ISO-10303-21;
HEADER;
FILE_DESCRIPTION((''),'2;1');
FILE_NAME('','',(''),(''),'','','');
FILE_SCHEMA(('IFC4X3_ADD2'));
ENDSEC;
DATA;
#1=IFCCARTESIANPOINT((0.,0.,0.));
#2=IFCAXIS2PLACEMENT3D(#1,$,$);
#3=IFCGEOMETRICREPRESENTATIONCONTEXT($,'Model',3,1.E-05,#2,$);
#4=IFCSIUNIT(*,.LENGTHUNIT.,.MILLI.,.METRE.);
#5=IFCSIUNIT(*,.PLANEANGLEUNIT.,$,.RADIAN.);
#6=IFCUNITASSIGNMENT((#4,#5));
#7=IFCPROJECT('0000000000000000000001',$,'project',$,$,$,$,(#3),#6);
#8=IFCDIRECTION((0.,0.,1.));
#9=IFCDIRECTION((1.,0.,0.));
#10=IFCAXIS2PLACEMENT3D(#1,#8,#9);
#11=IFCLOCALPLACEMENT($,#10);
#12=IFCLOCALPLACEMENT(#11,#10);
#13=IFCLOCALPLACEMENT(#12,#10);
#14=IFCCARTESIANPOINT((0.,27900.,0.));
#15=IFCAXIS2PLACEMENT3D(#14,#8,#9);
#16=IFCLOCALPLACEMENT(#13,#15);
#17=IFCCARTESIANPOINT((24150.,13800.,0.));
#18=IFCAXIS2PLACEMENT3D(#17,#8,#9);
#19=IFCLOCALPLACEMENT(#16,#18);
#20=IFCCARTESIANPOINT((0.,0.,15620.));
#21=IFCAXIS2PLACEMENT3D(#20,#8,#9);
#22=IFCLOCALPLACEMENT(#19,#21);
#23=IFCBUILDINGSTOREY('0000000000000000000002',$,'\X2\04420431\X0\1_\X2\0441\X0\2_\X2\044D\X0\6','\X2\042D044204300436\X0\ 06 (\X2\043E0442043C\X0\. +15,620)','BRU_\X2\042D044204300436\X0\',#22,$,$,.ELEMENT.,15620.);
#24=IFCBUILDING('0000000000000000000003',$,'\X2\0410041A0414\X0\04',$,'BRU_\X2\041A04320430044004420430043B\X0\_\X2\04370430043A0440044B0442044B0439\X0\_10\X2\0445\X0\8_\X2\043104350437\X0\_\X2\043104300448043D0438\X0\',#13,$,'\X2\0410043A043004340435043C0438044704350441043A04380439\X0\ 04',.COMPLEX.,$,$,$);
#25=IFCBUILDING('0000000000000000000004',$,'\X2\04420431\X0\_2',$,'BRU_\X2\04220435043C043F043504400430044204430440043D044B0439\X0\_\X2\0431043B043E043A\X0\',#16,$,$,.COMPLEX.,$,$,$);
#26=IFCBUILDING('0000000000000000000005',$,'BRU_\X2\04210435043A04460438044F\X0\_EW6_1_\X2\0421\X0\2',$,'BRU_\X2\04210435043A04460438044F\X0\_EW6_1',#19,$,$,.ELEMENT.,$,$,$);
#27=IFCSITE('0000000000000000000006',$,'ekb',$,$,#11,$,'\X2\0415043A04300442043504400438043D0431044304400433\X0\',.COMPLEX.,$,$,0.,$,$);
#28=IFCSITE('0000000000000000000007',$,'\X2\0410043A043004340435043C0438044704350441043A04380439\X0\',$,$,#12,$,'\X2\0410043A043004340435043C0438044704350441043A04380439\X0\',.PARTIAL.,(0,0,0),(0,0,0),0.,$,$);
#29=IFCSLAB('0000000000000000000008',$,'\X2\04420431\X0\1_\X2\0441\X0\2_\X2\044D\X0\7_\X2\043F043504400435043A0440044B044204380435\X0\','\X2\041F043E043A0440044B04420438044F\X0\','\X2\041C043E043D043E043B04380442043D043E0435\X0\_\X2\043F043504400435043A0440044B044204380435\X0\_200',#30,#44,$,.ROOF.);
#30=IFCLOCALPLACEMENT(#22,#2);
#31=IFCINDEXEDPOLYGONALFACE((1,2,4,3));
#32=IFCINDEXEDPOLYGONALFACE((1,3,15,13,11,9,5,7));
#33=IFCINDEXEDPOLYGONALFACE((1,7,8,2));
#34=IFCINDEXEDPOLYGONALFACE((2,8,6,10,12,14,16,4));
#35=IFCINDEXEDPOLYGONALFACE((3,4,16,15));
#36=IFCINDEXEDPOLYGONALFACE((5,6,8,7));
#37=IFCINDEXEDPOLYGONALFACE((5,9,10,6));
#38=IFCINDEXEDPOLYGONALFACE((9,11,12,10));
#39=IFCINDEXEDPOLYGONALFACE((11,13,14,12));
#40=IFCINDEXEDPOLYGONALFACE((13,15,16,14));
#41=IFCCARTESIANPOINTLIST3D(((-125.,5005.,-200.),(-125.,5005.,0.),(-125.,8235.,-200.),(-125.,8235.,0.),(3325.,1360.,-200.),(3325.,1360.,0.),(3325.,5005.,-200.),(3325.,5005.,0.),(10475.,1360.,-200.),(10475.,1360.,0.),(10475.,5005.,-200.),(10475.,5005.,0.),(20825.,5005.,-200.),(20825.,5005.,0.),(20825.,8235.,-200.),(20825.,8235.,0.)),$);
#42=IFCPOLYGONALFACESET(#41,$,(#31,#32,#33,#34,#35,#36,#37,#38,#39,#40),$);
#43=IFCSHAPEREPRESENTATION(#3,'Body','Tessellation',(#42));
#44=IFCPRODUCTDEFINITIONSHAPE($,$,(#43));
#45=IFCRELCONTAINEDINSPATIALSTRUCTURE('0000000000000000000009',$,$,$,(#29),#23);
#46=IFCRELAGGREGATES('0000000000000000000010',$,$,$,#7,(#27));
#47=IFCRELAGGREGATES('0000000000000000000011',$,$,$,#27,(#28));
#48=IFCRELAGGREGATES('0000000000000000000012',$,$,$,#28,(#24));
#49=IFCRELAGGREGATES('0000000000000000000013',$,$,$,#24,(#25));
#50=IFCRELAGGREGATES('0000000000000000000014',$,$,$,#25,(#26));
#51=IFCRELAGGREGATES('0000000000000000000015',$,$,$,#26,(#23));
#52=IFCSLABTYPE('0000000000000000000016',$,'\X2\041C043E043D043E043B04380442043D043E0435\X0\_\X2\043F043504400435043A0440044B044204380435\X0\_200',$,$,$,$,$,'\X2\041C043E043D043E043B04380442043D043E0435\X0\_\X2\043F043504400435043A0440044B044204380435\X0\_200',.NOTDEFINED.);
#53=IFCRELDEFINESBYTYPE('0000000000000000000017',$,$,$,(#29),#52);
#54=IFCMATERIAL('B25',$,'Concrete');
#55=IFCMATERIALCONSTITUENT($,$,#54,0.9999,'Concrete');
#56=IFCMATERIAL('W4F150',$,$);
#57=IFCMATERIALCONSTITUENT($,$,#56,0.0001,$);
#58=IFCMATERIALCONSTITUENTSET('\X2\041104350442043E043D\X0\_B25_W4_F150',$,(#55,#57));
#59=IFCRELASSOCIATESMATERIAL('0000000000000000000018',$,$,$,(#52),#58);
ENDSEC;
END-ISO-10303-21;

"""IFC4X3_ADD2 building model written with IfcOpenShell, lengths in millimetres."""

from ifc_helpers import new_model, si_unit, frame, origin, origin_with_axes, place, context, project, spatial, polyline, outline, extrude, material, constituent, constituent_set, type_object, element, save


model = new_model("IFC4X3_ADD2")

# Units and contexts
model_context = context("Model", 3, precision=1e-05, world=origin())
ifc_project = project(units=[si_unit("LENGTHUNIT", "METRE", prefix="MILLI"), si_unit("PLANEANGLEUNIT", "RADIAN")], contexts=[model_context])

# Sites, buildings, storey
site_1_placement = place(None, origin_with_axes())
site_1 = spatial("IfcSite", under=ifc_project, at=site_1_placement, Name="ekb", LongName="Екатеринбург", CompositionType="COMPLEX", RefElevation=0.0)
site_2_placement = place(site_1_placement, origin_with_axes())
site_2 = spatial("IfcSite", under=site_1, at=site_2_placement, Name="Академический", LongName="Академический", CompositionType="PARTIAL", RefLatitude=(0, 0, 0), RefLongitude=(0, 0, 0), RefElevation=0.0)
building_1_placement = place(site_2_placement, origin_with_axes())
building_1 = spatial("IfcBuilding", under=site_2, at=building_1_placement, Name="АКД04", ObjectType="BRU_Квартал_закрытый_10х8_без_башни", LongName="Академический 04", CompositionType="COMPLEX")
building_2_placement = place(building_1_placement, frame((0.0, 27900.0, 0.0), z_axis=(0.0, 0.0, 1.0), x_axis=(1.0, 0.0, 0.0)))
building_2 = spatial("IfcBuilding", under=building_1, at=building_2_placement, Name="тб_2", ObjectType="BRU_Температурный_блок", CompositionType="COMPLEX")
building_3_placement = place(building_2_placement, frame((24150.0, 13800.0, 0.0), z_axis=(0.0, 0.0, 1.0), x_axis=(1.0, 0.0, 0.0)))
building_3 = spatial("IfcBuilding", under=building_2, at=building_3_placement, Name="BRU_Секция_EW6_1_С2", ObjectType="BRU_Секция_EW6_1", CompositionType="ELEMENT")
storey_placement = place(building_3_placement, frame((0.0, 0.0, 15620.0), z_axis=(0.0, 0.0, 1.0), x_axis=(1.0, 0.0, 0.0)))
storey = spatial("IfcBuildingStorey", under=building_3, at=storey_placement, Name="тб1_с2_э6", Description="Этаж 06 (отм. +15,620)", ObjectType="BRU_Этаж", CompositionType="ELEMENT", Elevation=15620.0)

# Slab
ifc_material_1 = material(Name="B25", Category="Concrete")
ifc_constituent_1 = constituent(ifc_material_1, Category="Concrete", fraction=0.9999)
ifc_material_2 = material(Name="W4F150")
ifc_constituent_2 = constituent(ifc_material_2, fraction=0.0001)
ifc_constituent_set = constituent_set(constituents=[ifc_constituent_1, ifc_constituent_2], Name="Бетон_B25_W4_F150")
slab_type = type_object("IfcSlabType", Name="Монолитное_перекрытие_200", ElementType="Монолитное_перекрытие_200", PredefinedType="NOTDEFINED", material=ifc_constituent_set)
slab_placement = place(storey_placement, frame((0.0, 0.0, -200.0), z_axis=(0.0, 0.0, 1.0), x_axis=(1.0, 0.0, 0.0)))
element("IfcSlab", 1, at=slab_placement, inside=storey, type_object=slab_type, Name="тб1_с2_э7_перекрытие", Description="Покрытия", ObjectType="Монолитное_перекрытие_200", PredefinedType="ROOF", context=model_context, shape_type="SweptSolid", body=[
    extrude(outline(polyline([(-125.0, 5005.0), (-125.0, 8235.0), (20825.0, 8235.0), (20825.0, 5005.0), (10475.0, 5005.0), (10475.0, 1360.0), (3325.0, 1360.0), (3325.0, 5005.0), (-125.0, 5005.0)])), origin_with_axes(), (0.0, 0.0, 1.0), 200.0),
])

save(model, "model.ifc")
